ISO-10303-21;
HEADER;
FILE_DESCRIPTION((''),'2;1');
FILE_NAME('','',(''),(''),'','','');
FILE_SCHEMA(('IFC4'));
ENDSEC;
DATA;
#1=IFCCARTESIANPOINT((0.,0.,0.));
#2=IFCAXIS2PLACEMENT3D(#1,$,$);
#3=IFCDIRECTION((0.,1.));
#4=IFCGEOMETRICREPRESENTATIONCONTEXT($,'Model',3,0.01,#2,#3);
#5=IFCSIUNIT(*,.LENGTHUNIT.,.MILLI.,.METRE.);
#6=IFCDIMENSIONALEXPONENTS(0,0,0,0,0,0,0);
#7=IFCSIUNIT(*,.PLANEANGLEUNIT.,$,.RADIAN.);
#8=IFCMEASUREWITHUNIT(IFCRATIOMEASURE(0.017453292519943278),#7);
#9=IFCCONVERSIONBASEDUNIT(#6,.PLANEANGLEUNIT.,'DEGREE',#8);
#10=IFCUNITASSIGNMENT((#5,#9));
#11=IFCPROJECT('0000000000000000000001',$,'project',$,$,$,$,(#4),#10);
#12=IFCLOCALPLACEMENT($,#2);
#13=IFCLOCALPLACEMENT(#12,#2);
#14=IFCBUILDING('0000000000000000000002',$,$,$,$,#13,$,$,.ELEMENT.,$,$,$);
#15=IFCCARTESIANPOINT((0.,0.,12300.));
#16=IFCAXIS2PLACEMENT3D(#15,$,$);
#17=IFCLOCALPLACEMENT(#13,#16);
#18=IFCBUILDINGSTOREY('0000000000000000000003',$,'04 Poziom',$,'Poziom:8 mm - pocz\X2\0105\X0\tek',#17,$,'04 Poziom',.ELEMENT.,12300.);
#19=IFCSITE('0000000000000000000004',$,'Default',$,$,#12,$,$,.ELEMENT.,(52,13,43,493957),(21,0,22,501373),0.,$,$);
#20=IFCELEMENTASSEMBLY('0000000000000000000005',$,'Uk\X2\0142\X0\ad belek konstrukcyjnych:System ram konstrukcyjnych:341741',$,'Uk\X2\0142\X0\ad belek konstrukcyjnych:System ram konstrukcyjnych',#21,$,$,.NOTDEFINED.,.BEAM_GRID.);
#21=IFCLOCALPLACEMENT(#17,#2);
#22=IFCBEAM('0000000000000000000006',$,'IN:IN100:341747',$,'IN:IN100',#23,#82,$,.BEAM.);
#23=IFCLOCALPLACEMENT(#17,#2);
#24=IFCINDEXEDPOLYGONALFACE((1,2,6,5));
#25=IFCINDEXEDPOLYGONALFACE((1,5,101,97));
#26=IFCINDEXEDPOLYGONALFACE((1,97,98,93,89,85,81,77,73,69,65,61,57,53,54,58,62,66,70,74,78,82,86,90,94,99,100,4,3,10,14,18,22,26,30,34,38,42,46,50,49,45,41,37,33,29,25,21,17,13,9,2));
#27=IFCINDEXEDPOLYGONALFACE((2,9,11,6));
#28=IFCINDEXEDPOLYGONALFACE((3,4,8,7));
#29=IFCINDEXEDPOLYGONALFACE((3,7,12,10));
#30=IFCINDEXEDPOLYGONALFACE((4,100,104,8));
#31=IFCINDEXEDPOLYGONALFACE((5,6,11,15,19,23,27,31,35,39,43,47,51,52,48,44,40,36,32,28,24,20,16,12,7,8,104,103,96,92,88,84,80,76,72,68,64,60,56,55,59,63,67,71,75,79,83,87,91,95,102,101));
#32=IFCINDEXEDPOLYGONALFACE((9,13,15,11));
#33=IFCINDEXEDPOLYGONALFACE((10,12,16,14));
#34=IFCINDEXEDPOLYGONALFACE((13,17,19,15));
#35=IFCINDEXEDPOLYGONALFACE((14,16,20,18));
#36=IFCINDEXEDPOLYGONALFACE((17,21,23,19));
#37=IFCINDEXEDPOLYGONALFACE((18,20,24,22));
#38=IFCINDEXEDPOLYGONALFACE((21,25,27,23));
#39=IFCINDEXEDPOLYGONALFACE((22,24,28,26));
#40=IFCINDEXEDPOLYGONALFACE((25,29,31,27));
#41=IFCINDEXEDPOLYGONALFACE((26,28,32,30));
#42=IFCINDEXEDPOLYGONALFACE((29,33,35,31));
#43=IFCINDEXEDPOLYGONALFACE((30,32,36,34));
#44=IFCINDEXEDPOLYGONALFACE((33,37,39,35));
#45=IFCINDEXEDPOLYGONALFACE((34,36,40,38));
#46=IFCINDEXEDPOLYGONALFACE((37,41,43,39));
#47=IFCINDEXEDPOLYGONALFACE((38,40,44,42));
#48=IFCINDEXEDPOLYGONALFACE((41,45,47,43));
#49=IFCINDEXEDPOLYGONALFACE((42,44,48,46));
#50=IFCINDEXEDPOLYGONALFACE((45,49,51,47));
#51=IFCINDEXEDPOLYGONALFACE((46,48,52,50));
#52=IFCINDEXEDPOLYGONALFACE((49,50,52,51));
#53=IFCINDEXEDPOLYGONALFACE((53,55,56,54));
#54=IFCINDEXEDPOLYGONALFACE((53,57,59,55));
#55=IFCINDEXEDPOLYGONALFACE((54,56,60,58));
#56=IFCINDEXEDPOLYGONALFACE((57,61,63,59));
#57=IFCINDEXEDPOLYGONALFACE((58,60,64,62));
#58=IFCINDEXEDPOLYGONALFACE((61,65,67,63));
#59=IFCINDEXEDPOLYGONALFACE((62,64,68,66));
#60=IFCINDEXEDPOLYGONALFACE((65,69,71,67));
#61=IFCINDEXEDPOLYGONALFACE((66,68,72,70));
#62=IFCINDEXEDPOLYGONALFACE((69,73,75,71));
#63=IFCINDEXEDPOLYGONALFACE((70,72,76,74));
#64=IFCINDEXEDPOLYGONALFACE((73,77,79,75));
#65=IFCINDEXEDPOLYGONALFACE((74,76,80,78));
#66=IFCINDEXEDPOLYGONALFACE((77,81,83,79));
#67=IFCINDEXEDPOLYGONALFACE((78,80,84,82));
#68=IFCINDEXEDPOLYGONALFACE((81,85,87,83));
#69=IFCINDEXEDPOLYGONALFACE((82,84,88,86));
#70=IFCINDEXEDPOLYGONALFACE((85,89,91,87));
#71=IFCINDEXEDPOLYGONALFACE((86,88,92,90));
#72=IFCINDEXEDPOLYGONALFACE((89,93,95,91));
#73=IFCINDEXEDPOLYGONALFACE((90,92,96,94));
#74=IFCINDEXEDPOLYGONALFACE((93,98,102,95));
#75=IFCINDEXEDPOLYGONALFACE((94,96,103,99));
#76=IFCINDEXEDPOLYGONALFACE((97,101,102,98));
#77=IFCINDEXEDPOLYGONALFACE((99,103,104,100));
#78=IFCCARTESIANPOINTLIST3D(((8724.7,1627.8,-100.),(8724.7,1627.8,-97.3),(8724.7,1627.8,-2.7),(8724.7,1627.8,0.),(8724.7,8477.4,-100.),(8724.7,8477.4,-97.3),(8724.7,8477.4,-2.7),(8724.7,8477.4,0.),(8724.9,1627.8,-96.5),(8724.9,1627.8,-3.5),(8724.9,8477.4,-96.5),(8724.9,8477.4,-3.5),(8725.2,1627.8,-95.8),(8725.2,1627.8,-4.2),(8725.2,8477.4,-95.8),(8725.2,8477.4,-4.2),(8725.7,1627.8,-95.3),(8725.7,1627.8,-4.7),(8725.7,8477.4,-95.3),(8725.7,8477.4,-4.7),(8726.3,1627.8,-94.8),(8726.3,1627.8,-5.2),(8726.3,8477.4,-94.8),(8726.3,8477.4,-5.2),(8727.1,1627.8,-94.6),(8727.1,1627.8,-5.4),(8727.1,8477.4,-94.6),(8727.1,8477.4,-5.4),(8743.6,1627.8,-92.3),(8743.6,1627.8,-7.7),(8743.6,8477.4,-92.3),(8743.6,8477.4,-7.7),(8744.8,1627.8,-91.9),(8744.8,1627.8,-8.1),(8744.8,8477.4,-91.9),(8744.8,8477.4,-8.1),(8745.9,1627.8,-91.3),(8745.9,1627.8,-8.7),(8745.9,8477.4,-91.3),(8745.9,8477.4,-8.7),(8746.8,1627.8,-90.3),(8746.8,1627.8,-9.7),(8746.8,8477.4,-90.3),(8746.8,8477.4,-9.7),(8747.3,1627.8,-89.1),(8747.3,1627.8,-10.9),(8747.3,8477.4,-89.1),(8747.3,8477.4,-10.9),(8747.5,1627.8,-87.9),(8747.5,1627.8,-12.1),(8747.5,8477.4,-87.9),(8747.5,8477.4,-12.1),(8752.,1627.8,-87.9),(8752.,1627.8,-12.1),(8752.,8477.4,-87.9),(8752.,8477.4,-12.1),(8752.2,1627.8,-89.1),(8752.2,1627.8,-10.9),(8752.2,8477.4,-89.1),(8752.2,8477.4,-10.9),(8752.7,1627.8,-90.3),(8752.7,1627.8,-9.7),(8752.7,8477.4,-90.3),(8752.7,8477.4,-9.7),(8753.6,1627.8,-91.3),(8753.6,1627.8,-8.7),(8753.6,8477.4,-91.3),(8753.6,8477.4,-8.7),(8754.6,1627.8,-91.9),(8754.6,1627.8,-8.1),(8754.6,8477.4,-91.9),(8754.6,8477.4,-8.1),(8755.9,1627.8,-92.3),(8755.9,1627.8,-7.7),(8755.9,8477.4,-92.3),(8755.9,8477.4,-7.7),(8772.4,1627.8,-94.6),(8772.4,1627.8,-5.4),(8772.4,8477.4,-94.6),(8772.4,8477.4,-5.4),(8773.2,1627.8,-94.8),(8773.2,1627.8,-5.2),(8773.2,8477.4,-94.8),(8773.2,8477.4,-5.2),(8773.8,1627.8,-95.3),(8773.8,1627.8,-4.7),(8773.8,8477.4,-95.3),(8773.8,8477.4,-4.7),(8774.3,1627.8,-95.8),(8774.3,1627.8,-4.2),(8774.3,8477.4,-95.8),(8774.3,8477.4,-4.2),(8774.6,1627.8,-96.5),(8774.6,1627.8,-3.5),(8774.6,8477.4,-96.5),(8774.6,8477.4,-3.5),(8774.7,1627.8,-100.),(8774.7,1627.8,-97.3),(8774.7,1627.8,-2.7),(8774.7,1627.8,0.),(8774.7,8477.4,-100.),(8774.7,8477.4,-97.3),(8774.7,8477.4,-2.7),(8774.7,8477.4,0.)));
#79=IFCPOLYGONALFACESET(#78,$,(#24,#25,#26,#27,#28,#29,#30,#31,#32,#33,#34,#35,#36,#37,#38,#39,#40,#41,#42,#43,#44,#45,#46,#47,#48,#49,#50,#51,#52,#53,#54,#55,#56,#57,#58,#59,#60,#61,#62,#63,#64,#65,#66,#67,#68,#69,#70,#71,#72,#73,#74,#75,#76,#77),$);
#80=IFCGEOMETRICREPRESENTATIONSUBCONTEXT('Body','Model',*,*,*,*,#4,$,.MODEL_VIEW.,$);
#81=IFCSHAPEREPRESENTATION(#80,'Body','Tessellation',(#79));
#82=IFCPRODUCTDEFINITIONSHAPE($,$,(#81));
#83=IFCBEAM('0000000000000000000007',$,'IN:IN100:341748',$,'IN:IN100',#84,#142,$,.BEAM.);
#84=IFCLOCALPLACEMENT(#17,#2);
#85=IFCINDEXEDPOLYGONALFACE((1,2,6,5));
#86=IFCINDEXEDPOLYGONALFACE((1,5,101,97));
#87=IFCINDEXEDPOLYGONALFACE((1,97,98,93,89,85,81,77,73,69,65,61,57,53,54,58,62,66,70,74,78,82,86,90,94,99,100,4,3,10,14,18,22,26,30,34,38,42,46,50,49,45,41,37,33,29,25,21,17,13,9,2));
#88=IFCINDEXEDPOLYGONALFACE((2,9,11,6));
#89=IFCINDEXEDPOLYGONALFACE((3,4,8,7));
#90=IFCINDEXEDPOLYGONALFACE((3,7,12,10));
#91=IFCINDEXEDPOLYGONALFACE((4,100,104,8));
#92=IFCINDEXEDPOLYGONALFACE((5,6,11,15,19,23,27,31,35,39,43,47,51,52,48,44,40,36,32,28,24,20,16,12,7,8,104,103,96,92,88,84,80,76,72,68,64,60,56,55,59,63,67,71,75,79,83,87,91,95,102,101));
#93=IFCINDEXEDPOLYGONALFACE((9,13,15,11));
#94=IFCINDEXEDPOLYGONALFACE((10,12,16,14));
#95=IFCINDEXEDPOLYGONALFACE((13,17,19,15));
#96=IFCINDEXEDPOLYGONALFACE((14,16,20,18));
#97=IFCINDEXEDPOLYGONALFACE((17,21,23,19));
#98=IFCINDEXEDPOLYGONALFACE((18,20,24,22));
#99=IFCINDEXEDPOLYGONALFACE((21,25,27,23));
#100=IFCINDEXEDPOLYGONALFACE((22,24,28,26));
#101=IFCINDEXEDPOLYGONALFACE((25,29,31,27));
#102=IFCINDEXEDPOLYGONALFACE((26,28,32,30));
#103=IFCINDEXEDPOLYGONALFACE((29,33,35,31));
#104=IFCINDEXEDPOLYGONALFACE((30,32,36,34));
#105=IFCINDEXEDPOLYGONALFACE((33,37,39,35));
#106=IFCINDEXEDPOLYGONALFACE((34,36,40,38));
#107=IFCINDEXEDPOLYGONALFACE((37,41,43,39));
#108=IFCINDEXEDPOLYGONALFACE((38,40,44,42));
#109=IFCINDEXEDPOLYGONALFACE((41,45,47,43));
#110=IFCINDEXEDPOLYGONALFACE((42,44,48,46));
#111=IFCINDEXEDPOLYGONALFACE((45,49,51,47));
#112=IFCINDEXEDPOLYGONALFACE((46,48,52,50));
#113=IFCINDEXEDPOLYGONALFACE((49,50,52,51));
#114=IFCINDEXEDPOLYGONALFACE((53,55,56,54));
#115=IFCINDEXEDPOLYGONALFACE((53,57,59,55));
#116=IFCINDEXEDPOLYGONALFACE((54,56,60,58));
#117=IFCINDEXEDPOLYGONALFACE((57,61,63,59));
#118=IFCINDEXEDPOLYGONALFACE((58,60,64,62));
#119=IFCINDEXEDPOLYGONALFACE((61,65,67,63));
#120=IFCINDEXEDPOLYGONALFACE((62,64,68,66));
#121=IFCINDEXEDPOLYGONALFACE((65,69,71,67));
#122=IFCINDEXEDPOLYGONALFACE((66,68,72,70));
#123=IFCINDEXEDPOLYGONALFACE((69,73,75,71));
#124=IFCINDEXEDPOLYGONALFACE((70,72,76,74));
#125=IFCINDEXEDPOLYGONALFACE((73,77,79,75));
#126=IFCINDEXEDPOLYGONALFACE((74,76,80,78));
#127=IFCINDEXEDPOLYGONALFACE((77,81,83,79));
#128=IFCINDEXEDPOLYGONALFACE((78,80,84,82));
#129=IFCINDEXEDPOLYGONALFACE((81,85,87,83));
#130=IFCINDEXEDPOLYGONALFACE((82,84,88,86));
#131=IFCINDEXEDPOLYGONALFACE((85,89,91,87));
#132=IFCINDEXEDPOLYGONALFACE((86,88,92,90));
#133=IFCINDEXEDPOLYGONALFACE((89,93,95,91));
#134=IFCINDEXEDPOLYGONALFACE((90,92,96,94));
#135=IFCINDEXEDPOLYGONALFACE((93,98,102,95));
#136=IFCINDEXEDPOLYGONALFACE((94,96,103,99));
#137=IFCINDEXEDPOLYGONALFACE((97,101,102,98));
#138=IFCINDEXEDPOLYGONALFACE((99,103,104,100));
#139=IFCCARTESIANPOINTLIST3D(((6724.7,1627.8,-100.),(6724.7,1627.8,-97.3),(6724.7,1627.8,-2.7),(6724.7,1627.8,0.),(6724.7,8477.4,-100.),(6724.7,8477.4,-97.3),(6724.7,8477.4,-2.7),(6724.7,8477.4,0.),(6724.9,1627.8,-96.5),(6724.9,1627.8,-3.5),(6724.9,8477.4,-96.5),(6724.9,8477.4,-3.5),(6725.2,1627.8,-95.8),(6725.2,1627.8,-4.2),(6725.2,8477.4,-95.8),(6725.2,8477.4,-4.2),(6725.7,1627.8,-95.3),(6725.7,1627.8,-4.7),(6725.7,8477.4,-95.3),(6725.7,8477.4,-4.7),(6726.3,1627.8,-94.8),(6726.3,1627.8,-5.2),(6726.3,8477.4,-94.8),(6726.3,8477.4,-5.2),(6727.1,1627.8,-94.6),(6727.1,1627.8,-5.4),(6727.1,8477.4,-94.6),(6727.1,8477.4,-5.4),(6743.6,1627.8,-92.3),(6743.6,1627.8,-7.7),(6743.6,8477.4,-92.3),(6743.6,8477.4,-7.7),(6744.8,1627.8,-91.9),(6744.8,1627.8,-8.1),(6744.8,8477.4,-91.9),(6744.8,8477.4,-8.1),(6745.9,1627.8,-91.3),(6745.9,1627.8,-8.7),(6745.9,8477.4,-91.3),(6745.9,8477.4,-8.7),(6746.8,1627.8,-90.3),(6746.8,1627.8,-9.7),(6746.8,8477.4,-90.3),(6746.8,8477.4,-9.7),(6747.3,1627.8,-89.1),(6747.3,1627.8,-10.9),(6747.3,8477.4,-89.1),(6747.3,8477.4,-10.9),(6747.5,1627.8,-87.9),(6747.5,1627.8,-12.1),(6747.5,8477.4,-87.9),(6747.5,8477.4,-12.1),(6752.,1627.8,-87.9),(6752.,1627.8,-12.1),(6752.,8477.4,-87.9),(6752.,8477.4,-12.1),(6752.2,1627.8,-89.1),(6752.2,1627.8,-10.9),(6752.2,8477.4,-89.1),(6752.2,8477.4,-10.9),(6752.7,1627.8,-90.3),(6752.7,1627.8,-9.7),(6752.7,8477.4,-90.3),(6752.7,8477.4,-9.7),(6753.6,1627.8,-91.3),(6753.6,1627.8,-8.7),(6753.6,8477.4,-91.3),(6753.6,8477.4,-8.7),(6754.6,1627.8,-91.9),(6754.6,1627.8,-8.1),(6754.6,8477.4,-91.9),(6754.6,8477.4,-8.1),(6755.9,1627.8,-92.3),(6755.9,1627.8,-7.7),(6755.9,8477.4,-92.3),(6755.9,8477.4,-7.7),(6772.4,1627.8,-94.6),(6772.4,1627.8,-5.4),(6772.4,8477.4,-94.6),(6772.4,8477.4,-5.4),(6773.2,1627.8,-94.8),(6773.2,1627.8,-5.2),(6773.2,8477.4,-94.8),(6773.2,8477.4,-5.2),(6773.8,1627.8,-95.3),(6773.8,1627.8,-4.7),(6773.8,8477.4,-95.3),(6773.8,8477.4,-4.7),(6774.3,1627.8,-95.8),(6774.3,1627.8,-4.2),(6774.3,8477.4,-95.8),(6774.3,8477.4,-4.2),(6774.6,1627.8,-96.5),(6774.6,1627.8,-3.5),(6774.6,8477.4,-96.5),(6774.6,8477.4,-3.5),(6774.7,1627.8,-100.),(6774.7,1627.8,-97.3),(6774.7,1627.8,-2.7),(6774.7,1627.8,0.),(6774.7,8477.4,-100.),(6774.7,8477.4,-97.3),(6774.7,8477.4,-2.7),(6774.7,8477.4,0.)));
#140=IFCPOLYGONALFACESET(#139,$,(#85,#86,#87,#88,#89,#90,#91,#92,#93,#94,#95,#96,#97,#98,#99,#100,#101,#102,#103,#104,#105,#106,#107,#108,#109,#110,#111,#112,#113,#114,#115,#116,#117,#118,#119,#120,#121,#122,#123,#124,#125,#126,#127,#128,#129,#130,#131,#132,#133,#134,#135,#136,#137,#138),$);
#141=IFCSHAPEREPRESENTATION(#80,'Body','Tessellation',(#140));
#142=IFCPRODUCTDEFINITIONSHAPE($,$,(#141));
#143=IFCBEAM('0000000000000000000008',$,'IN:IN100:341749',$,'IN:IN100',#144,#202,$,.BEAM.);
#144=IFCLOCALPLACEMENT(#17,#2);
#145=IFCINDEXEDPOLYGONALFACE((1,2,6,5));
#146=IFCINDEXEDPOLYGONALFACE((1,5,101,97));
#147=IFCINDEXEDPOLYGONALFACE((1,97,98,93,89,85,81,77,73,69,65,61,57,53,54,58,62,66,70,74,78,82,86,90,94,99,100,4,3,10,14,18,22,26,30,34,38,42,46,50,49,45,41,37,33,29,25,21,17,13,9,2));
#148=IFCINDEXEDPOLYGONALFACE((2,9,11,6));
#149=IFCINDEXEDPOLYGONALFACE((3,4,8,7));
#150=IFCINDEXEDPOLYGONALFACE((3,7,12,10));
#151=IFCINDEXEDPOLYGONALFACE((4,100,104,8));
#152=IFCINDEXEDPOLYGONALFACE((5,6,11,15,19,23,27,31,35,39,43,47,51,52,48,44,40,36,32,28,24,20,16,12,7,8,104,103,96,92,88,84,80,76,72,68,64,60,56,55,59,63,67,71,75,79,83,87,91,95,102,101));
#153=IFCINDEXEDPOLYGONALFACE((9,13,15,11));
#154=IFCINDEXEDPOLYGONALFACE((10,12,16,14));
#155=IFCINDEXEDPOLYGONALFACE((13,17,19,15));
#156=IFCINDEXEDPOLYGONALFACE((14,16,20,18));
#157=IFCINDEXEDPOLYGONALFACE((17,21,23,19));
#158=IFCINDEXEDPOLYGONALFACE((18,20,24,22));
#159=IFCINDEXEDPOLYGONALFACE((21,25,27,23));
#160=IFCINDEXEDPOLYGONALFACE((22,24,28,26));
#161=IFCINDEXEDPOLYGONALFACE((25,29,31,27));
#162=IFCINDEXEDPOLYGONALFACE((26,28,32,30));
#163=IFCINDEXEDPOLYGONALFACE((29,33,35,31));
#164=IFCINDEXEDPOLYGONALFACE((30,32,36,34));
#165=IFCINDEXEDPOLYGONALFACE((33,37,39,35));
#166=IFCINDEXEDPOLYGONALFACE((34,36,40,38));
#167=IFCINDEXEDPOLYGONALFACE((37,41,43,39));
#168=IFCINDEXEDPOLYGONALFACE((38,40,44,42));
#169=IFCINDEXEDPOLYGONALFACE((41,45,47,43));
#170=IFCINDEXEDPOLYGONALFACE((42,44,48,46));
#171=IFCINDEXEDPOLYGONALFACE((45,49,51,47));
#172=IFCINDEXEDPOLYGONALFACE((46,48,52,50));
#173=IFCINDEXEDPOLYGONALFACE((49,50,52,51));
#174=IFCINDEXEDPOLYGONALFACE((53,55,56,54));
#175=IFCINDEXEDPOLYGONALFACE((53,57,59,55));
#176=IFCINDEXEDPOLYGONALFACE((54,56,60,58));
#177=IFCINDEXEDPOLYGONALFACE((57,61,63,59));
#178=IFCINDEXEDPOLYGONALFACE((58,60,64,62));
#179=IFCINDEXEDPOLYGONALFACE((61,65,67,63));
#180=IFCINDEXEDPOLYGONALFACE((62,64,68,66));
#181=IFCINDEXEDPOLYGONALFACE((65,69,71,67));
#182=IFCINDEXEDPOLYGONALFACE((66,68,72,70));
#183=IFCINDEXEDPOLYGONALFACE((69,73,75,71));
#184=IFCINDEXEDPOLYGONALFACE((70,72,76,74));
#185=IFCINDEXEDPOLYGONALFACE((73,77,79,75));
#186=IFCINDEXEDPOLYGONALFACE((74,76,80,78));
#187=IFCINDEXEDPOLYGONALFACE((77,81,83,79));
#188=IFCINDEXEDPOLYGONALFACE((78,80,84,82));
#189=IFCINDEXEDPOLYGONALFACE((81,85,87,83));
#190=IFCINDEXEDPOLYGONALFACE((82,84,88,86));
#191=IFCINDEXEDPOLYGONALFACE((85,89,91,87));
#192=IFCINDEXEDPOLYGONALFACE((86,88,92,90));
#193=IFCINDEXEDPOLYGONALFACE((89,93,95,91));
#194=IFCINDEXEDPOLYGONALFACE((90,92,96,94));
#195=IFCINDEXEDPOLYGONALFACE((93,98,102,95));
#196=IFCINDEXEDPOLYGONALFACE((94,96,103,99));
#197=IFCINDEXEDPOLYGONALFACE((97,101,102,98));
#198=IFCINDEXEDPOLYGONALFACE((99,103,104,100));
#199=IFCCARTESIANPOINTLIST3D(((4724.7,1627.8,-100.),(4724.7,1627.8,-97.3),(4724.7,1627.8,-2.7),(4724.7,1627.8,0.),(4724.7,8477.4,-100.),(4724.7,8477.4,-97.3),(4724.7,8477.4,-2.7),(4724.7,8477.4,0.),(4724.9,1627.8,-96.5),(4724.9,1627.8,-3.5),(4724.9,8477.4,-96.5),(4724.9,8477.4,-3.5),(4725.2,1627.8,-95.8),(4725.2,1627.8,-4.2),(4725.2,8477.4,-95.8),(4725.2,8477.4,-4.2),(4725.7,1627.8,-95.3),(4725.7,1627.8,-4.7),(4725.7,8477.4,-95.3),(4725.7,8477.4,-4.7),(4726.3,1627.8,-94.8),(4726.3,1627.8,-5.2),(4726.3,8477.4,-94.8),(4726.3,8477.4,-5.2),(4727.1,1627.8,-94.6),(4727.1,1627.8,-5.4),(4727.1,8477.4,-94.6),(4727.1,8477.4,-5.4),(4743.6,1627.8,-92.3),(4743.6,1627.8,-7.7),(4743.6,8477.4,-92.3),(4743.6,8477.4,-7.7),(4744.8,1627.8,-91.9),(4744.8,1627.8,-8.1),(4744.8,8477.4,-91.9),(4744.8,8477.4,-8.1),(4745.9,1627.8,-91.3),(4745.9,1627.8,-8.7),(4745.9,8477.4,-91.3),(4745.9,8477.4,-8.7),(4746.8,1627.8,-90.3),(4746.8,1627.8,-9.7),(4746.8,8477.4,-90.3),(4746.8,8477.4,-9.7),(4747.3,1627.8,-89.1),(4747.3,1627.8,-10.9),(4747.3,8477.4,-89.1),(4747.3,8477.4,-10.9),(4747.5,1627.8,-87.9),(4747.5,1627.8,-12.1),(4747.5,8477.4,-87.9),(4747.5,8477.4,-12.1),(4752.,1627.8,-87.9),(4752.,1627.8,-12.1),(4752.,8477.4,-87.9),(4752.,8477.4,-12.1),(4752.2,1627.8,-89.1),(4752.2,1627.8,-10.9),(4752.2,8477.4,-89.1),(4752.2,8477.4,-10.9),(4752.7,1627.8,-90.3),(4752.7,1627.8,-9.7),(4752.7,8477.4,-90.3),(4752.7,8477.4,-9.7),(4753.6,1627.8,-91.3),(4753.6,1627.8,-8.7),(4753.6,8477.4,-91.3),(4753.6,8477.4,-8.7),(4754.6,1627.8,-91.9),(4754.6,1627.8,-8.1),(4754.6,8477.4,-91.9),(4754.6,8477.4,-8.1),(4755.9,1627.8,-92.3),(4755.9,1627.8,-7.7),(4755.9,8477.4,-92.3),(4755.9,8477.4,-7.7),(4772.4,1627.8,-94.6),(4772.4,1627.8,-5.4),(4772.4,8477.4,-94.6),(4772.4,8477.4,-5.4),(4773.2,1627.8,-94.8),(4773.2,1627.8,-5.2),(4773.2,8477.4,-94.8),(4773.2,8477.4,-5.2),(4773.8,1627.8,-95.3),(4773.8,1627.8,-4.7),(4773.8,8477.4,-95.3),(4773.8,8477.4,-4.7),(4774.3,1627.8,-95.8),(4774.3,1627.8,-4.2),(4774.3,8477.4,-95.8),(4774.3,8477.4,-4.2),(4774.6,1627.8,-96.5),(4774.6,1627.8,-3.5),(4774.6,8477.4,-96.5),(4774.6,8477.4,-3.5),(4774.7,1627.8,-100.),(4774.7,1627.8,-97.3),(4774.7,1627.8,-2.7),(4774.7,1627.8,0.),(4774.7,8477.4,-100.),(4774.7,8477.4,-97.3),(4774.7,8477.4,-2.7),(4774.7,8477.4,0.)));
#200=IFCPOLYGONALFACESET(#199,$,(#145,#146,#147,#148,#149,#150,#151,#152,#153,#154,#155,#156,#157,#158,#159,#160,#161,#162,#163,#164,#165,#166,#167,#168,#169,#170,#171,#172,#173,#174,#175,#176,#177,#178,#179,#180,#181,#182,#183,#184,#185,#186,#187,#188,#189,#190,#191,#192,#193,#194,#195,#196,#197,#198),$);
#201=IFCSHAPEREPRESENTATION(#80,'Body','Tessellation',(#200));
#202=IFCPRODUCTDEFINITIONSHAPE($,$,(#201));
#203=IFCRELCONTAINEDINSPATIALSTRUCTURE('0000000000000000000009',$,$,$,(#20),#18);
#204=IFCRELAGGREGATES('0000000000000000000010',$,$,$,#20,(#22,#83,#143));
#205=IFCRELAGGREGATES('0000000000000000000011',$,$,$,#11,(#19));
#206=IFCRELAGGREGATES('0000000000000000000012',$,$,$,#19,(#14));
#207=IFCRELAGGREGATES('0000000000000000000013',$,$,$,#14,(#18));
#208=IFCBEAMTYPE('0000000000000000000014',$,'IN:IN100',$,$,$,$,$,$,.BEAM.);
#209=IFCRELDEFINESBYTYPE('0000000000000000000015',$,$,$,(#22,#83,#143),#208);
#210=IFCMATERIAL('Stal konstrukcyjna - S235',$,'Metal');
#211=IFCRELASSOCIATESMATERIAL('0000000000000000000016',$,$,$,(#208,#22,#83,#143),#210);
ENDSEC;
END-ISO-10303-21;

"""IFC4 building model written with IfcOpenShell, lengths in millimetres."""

from ifc_helpers import new_model, entity, si_unit, converted_unit, direction, frame, origin, place, context, subcontext, project, spatial, line, arc, indexed_curve, outline, extrude, source, transform, mapped, material, type_object, type_shapes, element, aggregate, save


model = new_model("IFC4")

# Units and contexts
model_context = context("Model", 3, precision=0.01, world=origin(), true_north=direction((0.0, 1.0)))
body_context = subcontext(model_context, "Body", "Model", "MODEL_VIEW")
ifc_project = project(units=[si_unit("LENGTHUNIT", "METRE", prefix="MILLI"), converted_unit("PLANEANGLEUNIT", "DEGREE", entity("IfcRatioMeasure", 0.017453292519943278), si_unit("PLANEANGLEUNIT", "RADIAN"), dimensions=[0, 0, 0, 0, 0, 0, 0])], contexts=[model_context])

# Site, building, storey
site_placement = place(None, origin())
site = spatial("IfcSite", under=ifc_project, at=site_placement, Name="Default", CompositionType="ELEMENT", RefLatitude=(52, 13, 43, 493957), RefLongitude=(21, 0, 22, 501373), RefElevation=0.0)
building_placement = place(site_placement, origin())
building = spatial("IfcBuilding", under=site, at=building_placement, CompositionType="ELEMENT")
storey_placement = place(building_placement, frame((0.0, 0.0, 12300.0)))
storey = spatial("IfcBuildingStorey", under=building, at=storey_placement, Name="04 Poziom", ObjectType="Poziom:8 mm - początek", LongName="04 Poziom", CompositionType="ELEMENT", Elevation=12300.0)

# Shared definitions
ifc_material_1 = material(Name="Stal konstrukcyjna - S235", Category="Metal")

# Element assembly, beams
beam_type_1 = type_object("IfcBeamType", Name="IN:IN100", PredefinedType="BEAM", material=ifc_material_1)
shared_shape_1 = source(origin(), body_context, "Body", "SweptSolid", [
    extrude(outline(indexed_curve([(47.3, -25.0), (50.0, -25.0), (50.0, 25.0), (47.3, 25.0), (45.5, 24.3), (44.6, 22.7), (42.3, 6.1), (40.8, 3.4), (37.9, 2.2), (-37.9, 2.2), (-40.8, 3.4), (-42.3, 6.1), (-44.6, 22.7), (-45.5, 24.3), (-47.3, 25.0), (-50.0, 25.0), (-50.0, -25.0), (-47.3, -25.0), (-45.5, -24.3), (-44.6, -22.7), (-42.3, -6.1), (-40.8, -3.4), (-37.9, -2.2), (37.9, -2.2), (40.8, -3.4), (42.3, -6.1), (44.6, -22.7), (45.5, -24.3)], segments=[line(1, 2, 3, 4), arc(4, 5, 6), line(6, 7), arc(7, 8, 9), line(9, 10), arc(10, 11, 12), line(12, 13), arc(13, 14, 15), line(15, 16, 17, 18), arc(18, 19, 20), line(20, 21), arc(21, 22, 23), line(23, 24), arc(24, 25, 26), line(26, 27), arc(27, 28, 1)], self_intersect=False)), frame((-3424.8, 0.0, 0.0), z_axis=(1.0, 0.0, 0.0), x_axis=(0.0, 0.0, -1.0)), (0.0, 0.0, 1.0), 6849.6),
])
type_shapes(beam_type_1, [shared_shape_1])
assembly_1_placement = place(storey_placement, origin())
assembly_1 = element("IfcElementAssembly", 1, at=assembly_1_placement, inside=storey, Name="Układ belek konstrukcyjnych:System ram konstrukcyjnych:341741", ObjectType="Układ belek konstrukcyjnych:System ram konstrukcyjnych", AssemblyPlace="NOTDEFINED", PredefinedType="BEAM_GRID")
beam_1_placement = place(assembly_1_placement, frame((8749.7, 5052.6, -50.0), z_axis=(0.0, 0.0, 1.0), x_axis=(0.0, -1.0, 0.0)))
beam_1 = element("IfcBeam", 2, at=beam_1_placement, type_object=beam_type_1, material=ifc_material_1, Name="IN:IN100:341747", ObjectType="IN:IN100", PredefinedType="BEAM", context=body_context, shape_type="MappedRepresentation", body=[
    mapped(shared_shape_1, transform((0.0, 0.0, 0.0), scale=1.0)),
])
beam_2_placement = place(assembly_1_placement, frame((6749.7, 5052.6, -50.0), z_axis=(0.0, 0.0, 1.0), x_axis=(0.0, -1.0, 0.0)))
beam_2 = element("IfcBeam", 3, at=beam_2_placement, type_object=beam_type_1, material=ifc_material_1, Name="IN:IN100:341748", ObjectType="IN:IN100", PredefinedType="BEAM", context=body_context, shape_type="MappedRepresentation", body=[
    mapped(shared_shape_1, transform((0.0, 0.0, 0.0), scale=1.0)),
])
beam_3_placement = place(assembly_1_placement, frame((4749.7, 5052.6, -50.0), z_axis=(0.0, 0.0, 1.0), x_axis=(0.0, -1.0, 0.0)))
beam_3 = element("IfcBeam", 4, at=beam_3_placement, type_object=beam_type_1, material=ifc_material_1, Name="IN:IN100:341749", ObjectType="IN:IN100", PredefinedType="BEAM", context=body_context, shape_type="MappedRepresentation", body=[
    mapped(shared_shape_1, transform((0.0, 0.0, 0.0), scale=1.0)),
])
aggregate(assembly_1, [beam_1, beam_2, beam_3])

save(model, "model.ifc")
